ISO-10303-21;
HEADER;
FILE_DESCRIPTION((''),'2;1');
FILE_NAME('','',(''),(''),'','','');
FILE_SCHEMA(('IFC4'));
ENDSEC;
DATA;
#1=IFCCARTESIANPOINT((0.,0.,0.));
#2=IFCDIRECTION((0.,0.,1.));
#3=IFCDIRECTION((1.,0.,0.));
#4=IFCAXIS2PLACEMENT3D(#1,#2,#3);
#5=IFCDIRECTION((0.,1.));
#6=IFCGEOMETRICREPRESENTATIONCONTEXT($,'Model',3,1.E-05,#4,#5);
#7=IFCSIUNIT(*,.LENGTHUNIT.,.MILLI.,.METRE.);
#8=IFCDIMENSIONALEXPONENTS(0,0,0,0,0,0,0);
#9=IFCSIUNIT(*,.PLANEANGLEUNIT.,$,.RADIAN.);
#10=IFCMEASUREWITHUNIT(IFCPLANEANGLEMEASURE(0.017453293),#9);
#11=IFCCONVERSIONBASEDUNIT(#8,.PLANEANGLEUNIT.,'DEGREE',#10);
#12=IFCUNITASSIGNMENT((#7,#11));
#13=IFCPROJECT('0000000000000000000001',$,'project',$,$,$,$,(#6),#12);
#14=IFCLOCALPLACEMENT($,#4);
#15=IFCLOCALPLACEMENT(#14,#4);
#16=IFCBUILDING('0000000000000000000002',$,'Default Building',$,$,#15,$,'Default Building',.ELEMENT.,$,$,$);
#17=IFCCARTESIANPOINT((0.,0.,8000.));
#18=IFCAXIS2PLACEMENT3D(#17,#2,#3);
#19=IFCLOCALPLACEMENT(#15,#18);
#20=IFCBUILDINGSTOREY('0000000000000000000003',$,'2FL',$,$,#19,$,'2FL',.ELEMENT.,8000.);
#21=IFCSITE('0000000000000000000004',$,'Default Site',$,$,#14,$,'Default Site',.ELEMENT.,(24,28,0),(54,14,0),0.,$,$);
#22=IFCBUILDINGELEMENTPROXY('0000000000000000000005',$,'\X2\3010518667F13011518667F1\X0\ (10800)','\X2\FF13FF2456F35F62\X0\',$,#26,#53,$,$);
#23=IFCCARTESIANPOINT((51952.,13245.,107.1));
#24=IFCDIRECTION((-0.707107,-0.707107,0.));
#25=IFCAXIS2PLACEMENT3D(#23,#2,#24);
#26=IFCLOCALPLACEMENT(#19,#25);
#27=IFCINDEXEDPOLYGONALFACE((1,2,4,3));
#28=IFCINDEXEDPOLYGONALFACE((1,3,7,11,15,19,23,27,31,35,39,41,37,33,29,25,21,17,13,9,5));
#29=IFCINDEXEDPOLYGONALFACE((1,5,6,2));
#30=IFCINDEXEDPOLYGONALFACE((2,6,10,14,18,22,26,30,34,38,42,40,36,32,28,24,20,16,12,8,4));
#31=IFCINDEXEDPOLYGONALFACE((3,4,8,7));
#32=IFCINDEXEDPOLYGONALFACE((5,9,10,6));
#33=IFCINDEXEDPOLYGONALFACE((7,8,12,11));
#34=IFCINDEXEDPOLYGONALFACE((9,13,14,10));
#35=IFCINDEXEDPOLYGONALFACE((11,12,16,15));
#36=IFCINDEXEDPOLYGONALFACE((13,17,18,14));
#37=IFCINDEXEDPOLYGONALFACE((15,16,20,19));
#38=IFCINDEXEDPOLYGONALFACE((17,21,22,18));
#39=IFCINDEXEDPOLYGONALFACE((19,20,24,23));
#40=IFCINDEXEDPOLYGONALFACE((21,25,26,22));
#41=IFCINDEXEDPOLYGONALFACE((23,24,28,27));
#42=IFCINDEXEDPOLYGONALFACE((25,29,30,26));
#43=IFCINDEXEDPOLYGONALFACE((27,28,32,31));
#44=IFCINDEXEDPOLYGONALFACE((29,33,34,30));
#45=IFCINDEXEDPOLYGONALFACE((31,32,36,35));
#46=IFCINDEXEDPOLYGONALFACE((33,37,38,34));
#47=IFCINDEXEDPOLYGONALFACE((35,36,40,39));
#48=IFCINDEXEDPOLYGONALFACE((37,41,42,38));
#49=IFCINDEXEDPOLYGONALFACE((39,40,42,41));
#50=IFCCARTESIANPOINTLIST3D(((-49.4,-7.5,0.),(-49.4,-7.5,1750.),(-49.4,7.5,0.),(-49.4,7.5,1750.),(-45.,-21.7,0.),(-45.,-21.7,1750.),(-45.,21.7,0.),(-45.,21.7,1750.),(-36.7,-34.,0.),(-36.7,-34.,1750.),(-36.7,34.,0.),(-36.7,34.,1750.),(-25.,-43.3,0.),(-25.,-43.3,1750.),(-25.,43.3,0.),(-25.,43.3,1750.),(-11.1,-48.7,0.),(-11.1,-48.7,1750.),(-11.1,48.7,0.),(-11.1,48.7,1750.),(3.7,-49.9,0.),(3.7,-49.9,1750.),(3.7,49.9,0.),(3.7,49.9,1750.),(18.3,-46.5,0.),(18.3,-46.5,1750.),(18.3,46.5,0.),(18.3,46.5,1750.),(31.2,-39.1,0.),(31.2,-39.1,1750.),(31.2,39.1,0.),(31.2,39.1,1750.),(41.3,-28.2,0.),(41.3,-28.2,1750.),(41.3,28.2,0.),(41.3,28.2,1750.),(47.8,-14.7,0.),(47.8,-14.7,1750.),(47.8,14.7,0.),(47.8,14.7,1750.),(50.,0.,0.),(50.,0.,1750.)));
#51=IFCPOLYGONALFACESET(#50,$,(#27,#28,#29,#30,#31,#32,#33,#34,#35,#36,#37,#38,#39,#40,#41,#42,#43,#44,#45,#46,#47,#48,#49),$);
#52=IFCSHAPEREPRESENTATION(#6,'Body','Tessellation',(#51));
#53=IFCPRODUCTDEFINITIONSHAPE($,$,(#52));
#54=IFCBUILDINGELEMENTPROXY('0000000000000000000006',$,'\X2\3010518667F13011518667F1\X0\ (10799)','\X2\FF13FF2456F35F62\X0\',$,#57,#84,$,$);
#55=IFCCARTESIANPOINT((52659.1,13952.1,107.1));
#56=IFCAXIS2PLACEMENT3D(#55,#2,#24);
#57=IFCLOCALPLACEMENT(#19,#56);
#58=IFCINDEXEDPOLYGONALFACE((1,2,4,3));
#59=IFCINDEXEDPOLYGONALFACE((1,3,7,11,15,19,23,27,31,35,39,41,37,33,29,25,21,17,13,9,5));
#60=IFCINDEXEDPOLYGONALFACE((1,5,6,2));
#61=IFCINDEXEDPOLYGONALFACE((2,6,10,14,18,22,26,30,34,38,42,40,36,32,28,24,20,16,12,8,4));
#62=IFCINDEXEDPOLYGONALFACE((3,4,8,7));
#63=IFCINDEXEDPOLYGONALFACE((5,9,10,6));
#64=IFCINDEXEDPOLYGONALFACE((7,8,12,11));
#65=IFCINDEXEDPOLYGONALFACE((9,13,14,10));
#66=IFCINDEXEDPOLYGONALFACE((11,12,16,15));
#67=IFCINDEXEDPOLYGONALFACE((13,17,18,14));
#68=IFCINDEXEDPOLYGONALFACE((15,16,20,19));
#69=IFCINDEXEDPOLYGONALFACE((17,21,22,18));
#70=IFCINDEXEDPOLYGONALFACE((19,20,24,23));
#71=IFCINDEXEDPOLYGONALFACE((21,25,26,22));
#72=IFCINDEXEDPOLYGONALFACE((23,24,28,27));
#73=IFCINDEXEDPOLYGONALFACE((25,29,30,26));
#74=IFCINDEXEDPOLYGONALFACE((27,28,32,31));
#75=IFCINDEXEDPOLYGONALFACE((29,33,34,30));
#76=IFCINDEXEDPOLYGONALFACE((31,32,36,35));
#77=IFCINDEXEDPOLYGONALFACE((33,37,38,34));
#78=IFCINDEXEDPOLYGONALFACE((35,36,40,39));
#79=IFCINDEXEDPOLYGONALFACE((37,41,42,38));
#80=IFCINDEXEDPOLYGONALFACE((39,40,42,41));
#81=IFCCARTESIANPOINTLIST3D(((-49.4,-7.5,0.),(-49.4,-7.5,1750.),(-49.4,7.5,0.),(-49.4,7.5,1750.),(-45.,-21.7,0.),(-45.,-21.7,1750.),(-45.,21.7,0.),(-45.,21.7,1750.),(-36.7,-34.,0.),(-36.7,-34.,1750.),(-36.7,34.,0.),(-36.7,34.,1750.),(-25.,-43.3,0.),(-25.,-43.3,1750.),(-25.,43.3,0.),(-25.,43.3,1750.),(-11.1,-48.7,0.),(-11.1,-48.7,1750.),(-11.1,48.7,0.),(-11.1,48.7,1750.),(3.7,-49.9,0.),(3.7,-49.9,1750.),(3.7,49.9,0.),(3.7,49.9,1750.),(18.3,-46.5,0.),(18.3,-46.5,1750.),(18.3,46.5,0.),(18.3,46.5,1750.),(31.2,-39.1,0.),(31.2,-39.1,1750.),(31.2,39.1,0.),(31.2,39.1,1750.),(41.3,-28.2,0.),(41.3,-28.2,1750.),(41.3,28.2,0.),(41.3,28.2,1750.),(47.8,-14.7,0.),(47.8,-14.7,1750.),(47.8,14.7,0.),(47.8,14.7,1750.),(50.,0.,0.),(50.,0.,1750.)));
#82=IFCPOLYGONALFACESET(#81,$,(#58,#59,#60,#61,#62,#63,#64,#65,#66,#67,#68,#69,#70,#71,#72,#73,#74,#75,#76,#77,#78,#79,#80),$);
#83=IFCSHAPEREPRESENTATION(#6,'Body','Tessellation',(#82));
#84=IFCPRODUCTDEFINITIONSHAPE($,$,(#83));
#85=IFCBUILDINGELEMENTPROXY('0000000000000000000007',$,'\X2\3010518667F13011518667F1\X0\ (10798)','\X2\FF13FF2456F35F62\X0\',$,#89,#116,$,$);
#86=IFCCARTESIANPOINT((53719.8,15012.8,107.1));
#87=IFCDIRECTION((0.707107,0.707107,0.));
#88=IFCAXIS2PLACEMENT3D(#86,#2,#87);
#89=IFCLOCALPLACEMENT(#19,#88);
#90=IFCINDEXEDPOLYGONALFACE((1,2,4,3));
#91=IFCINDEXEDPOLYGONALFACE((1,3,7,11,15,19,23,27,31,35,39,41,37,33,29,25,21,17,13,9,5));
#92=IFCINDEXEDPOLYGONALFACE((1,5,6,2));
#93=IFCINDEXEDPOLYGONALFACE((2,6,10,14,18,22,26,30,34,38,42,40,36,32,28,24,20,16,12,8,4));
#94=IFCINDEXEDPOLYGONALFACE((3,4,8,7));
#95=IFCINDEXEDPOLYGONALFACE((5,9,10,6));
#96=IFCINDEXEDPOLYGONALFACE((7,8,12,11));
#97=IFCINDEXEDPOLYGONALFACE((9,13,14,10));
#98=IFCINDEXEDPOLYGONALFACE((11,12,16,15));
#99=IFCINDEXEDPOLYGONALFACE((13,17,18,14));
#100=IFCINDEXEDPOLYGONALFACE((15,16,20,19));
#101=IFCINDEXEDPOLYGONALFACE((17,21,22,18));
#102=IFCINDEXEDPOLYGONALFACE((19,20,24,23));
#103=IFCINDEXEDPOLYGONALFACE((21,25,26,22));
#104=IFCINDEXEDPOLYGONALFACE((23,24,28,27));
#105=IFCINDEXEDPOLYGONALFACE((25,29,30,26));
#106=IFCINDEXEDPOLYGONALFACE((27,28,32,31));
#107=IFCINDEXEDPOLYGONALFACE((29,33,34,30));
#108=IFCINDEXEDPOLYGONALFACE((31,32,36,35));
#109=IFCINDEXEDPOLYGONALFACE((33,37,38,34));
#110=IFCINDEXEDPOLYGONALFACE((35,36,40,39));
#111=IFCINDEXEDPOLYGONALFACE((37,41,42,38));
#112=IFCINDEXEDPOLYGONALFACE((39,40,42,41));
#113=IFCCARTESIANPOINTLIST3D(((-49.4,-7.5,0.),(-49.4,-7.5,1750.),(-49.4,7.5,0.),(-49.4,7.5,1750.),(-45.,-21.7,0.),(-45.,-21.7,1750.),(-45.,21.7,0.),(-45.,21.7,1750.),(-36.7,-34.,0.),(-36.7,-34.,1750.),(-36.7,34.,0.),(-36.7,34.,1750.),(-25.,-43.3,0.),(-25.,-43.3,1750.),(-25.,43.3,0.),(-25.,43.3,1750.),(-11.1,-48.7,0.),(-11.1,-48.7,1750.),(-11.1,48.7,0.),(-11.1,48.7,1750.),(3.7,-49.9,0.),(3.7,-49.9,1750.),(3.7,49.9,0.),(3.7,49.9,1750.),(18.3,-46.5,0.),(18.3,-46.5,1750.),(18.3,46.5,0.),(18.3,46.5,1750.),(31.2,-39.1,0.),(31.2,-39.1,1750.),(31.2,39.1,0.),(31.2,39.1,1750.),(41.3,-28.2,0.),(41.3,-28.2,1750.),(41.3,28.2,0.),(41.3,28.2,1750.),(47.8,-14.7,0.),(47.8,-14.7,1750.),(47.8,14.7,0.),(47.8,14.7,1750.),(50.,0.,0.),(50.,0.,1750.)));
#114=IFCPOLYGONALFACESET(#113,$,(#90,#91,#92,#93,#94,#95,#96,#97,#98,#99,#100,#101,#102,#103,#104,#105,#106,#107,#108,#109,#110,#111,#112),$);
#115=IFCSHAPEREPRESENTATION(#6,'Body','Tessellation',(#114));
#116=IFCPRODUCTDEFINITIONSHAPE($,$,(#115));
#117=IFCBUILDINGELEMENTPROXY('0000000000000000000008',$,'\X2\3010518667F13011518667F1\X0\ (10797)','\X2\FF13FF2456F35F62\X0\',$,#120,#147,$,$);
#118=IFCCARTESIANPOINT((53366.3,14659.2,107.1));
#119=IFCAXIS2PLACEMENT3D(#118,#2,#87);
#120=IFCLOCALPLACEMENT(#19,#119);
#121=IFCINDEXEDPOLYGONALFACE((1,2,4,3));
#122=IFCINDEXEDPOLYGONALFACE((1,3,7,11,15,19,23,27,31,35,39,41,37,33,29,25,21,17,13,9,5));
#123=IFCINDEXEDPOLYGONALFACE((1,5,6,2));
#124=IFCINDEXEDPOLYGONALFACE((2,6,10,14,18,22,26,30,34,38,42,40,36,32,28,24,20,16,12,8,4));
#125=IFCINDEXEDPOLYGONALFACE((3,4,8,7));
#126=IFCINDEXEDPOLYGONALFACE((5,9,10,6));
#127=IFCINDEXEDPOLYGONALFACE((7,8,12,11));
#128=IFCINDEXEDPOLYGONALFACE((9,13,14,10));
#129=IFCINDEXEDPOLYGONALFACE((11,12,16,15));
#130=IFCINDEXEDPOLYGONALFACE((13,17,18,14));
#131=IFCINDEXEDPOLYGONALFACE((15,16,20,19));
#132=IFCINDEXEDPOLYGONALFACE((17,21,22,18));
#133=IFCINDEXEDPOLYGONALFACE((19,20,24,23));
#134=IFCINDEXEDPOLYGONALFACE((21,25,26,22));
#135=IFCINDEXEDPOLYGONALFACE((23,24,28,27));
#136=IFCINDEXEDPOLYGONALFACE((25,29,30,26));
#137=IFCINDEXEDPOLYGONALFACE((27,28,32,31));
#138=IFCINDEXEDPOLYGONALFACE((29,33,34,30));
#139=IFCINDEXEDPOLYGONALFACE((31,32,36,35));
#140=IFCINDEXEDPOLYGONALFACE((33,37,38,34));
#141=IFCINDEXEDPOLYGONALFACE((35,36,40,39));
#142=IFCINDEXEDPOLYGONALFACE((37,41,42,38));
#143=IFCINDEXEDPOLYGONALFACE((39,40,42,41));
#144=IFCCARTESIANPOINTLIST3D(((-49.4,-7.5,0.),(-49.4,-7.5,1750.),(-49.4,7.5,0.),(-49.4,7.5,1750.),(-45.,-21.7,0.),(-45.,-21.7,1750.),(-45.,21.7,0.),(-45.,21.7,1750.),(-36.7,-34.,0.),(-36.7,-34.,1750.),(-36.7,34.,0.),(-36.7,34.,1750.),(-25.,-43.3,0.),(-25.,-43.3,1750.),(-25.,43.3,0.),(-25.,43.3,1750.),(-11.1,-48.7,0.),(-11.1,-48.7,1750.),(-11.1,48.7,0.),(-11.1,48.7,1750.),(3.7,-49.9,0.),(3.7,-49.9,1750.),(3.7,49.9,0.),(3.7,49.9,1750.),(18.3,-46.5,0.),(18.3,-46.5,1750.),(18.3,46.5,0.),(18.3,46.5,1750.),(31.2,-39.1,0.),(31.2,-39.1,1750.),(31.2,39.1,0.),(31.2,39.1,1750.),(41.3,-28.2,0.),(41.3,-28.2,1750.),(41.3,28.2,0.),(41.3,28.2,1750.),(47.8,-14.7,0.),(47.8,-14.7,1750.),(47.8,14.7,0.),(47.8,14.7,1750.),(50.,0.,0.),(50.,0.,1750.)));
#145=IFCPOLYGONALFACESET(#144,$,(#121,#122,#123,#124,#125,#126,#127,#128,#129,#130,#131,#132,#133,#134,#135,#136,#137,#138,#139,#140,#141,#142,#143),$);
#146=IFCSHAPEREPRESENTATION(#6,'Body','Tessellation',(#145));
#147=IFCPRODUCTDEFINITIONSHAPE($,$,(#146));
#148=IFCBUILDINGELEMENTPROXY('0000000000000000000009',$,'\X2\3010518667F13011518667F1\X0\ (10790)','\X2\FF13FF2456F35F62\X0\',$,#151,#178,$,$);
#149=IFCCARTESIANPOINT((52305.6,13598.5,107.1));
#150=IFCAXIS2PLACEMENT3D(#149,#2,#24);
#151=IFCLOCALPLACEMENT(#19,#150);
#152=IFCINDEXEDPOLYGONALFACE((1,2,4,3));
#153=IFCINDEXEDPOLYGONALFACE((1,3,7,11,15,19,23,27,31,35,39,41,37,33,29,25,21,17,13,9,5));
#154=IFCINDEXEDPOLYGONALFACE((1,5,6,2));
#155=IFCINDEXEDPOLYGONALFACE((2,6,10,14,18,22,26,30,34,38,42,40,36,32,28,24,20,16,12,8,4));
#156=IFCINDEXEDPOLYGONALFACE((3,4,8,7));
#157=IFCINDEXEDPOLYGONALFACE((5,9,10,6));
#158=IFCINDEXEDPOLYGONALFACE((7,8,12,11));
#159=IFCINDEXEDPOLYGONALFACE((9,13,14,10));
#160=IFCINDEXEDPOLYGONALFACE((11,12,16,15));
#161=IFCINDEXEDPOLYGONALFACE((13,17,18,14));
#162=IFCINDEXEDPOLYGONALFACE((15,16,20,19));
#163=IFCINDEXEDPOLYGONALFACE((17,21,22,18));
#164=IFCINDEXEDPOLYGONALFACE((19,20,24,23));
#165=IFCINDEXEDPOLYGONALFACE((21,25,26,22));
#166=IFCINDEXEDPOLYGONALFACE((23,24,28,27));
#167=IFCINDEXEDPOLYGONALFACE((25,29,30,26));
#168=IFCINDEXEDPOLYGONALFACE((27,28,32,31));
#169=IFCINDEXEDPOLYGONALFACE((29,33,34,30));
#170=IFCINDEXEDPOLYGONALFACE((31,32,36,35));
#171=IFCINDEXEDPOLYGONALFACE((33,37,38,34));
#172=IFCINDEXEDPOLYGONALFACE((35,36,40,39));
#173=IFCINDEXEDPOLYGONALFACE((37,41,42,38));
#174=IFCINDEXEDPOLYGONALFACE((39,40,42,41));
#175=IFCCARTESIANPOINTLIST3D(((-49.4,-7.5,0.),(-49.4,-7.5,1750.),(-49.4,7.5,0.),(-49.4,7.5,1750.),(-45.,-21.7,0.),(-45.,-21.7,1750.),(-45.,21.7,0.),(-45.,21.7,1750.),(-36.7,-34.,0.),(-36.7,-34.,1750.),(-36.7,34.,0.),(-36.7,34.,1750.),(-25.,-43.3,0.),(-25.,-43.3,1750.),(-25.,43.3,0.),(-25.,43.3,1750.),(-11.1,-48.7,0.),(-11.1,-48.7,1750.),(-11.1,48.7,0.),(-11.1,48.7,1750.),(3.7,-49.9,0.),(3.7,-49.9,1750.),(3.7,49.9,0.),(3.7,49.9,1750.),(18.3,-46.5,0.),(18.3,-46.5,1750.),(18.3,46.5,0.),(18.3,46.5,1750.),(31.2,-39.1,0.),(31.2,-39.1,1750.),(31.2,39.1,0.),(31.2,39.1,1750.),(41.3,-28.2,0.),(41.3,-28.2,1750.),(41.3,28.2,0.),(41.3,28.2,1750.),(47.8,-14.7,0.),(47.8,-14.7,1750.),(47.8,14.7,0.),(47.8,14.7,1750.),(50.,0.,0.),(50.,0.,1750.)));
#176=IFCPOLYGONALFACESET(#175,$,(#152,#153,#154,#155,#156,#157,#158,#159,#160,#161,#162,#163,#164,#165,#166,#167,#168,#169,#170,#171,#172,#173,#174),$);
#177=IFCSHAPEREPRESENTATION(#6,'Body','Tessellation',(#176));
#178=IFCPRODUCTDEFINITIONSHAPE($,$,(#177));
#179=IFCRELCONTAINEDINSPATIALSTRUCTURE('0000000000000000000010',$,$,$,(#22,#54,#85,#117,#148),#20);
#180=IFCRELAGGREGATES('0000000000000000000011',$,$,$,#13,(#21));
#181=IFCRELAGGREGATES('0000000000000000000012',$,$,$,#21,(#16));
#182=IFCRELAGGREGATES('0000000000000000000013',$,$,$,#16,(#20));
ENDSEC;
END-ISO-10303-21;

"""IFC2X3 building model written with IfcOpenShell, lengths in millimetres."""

from ifc_helpers import new_model, entity, si_unit, converted_unit, direction, frame, origin_with_axes, origin_2d_with_axis, place, context, project, spatial, circle, extrude, source, transform, mapped, element, save


model = new_model("IFC2X3")

# Units and contexts
model_context = context("Model", 3, precision=1e-05, world=origin_with_axes(), true_north=direction((0.0, 1.0)))
ifc_project = project(units=[si_unit("LENGTHUNIT", "METRE", prefix="MILLI"), converted_unit("PLANEANGLEUNIT", "DEGREE", entity("IfcPlaneAngleMeasure", 0.017453293), si_unit("PLANEANGLEUNIT", "RADIAN"), dimensions=[0, 0, 0, 0, 0, 0, 0])], contexts=[model_context])

# Site, building, storey
site_placement = place(None, origin_with_axes())
site = spatial("IfcSite", under=ifc_project, at=site_placement, Name="Default Site", LongName="Default Site", CompositionType="ELEMENT", RefLatitude=(24, 28, 0), RefLongitude=(54, 14, 0), RefElevation=0.0)
building_placement = place(site_placement, origin_with_axes())
building = spatial("IfcBuilding", under=site, at=building_placement, Name="Default Building", LongName="Default Building", CompositionType="ELEMENT")
storey_placement = place(building_placement, frame((0.0, 0.0, 8000.0), z_axis=(0.0, 0.0, 1.0), x_axis=(1.0, 0.0, 0.0)))
storey = spatial("IfcBuildingStorey", under=building, at=storey_placement, Name="2FL", LongName="2FL", CompositionType="ELEMENT", Elevation=8000.0)

# Building element proxies
shared_shape_1 = source(origin_with_axes(), model_context, "Body", "SweptSolid", [
    extrude(circle(Radius=50.0, at=origin_2d_with_axis()), frame((0.0, 0.0, 0.0), z_axis=(0.0, 0.0, 1.0), x_axis=(1.0, 0.0, 0.0)), (0.0, 0.0, 1.0), 1750.0),
])
proxy_1_placement = place(storey_placement, frame((51952.0, 13245.0, 107.1), z_axis=(0.0, 0.0, 1.0), x_axis=(-0.707107, -0.707107, 0.0)))
element("IfcBuildingElementProxy", 1, at=proxy_1_placement, inside=storey, Name="【円柱】円柱 (10800)", Description="３Ｄ図形", context=model_context, shape_type="MappedRepresentation", body=[
    mapped(shared_shape_1, transform((0.0, 0.0, 0.0))),
])
shared_shape_2 = source(origin_with_axes(), model_context, "Body", "SweptSolid", [
    extrude(circle(Radius=50.0, at=origin_2d_with_axis()), frame((0.0, 0.0, 0.0), z_axis=(0.0, 0.0, 1.0), x_axis=(1.0, 0.0, 0.0)), (0.0, 0.0, 1.0), 1750.0),
])
proxy_2_placement = place(storey_placement, frame((52659.1, 13952.1, 107.1), z_axis=(0.0, 0.0, 1.0), x_axis=(-0.707107, -0.707107, 0.0)))
element("IfcBuildingElementProxy", 2, at=proxy_2_placement, inside=storey, Name="【円柱】円柱 (10799)", Description="３Ｄ図形", context=model_context, shape_type="MappedRepresentation", body=[
    mapped(shared_shape_2, transform((0.0, 0.0, 0.0))),
])
shared_shape_3 = source(origin_with_axes(), model_context, "Body", "SweptSolid", [
    extrude(circle(Radius=50.0, at=origin_2d_with_axis()), frame((0.0, 0.0, 0.0), z_axis=(0.0, 0.0, 1.0), x_axis=(1.0, 0.0, 0.0)), (0.0, 0.0, 1.0), 1750.0),
])
proxy_3_placement = place(storey_placement, frame((53719.8, 15012.8, 107.1), z_axis=(0.0, 0.0, 1.0), x_axis=(0.707107, 0.707107, 0.0)))
element("IfcBuildingElementProxy", 3, at=proxy_3_placement, inside=storey, Name="【円柱】円柱 (10798)", Description="３Ｄ図形", context=model_context, shape_type="MappedRepresentation", body=[
    mapped(shared_shape_3, transform((0.0, 0.0, 0.0))),
])
shared_shape_4 = source(origin_with_axes(), model_context, "Body", "SweptSolid", [
    extrude(circle(Radius=50.0, at=origin_2d_with_axis()), frame((0.0, 0.0, 0.0), z_axis=(0.0, 0.0, 1.0), x_axis=(1.0, 0.0, 0.0)), (0.0, 0.0, 1.0), 1750.0),
])
proxy_4_placement = place(storey_placement, frame((53366.3, 14659.2, 107.1), z_axis=(0.0, 0.0, 1.0), x_axis=(0.707107, 0.707107, 0.0)))
element("IfcBuildingElementProxy", 4, at=proxy_4_placement, inside=storey, Name="【円柱】円柱 (10797)", Description="３Ｄ図形", context=model_context, shape_type="MappedRepresentation", body=[
    mapped(shared_shape_4, transform((0.0, 0.0, 0.0))),
])
shared_shape_5 = source(origin_with_axes(), model_context, "Body", "SweptSolid", [
    extrude(circle(Radius=50.0, at=origin_2d_with_axis()), frame((0.0, 0.0, 0.0), z_axis=(0.0, 0.0, 1.0), x_axis=(1.0, 0.0, 0.0)), (0.0, 0.0, 1.0), 1750.0),
])
proxy_5_placement = place(storey_placement, frame((52305.6, 13598.5, 107.1), z_axis=(0.0, 0.0, 1.0), x_axis=(-0.707107, -0.707107, 0.0)))
element("IfcBuildingElementProxy", 5, at=proxy_5_placement, inside=storey, Name="【円柱】円柱 (10790)", Description="３Ｄ図形", context=model_context, shape_type="MappedRepresentation", body=[
    mapped(shared_shape_5, transform((0.0, 0.0, 0.0))),
])

save(model, "model.ifc")
